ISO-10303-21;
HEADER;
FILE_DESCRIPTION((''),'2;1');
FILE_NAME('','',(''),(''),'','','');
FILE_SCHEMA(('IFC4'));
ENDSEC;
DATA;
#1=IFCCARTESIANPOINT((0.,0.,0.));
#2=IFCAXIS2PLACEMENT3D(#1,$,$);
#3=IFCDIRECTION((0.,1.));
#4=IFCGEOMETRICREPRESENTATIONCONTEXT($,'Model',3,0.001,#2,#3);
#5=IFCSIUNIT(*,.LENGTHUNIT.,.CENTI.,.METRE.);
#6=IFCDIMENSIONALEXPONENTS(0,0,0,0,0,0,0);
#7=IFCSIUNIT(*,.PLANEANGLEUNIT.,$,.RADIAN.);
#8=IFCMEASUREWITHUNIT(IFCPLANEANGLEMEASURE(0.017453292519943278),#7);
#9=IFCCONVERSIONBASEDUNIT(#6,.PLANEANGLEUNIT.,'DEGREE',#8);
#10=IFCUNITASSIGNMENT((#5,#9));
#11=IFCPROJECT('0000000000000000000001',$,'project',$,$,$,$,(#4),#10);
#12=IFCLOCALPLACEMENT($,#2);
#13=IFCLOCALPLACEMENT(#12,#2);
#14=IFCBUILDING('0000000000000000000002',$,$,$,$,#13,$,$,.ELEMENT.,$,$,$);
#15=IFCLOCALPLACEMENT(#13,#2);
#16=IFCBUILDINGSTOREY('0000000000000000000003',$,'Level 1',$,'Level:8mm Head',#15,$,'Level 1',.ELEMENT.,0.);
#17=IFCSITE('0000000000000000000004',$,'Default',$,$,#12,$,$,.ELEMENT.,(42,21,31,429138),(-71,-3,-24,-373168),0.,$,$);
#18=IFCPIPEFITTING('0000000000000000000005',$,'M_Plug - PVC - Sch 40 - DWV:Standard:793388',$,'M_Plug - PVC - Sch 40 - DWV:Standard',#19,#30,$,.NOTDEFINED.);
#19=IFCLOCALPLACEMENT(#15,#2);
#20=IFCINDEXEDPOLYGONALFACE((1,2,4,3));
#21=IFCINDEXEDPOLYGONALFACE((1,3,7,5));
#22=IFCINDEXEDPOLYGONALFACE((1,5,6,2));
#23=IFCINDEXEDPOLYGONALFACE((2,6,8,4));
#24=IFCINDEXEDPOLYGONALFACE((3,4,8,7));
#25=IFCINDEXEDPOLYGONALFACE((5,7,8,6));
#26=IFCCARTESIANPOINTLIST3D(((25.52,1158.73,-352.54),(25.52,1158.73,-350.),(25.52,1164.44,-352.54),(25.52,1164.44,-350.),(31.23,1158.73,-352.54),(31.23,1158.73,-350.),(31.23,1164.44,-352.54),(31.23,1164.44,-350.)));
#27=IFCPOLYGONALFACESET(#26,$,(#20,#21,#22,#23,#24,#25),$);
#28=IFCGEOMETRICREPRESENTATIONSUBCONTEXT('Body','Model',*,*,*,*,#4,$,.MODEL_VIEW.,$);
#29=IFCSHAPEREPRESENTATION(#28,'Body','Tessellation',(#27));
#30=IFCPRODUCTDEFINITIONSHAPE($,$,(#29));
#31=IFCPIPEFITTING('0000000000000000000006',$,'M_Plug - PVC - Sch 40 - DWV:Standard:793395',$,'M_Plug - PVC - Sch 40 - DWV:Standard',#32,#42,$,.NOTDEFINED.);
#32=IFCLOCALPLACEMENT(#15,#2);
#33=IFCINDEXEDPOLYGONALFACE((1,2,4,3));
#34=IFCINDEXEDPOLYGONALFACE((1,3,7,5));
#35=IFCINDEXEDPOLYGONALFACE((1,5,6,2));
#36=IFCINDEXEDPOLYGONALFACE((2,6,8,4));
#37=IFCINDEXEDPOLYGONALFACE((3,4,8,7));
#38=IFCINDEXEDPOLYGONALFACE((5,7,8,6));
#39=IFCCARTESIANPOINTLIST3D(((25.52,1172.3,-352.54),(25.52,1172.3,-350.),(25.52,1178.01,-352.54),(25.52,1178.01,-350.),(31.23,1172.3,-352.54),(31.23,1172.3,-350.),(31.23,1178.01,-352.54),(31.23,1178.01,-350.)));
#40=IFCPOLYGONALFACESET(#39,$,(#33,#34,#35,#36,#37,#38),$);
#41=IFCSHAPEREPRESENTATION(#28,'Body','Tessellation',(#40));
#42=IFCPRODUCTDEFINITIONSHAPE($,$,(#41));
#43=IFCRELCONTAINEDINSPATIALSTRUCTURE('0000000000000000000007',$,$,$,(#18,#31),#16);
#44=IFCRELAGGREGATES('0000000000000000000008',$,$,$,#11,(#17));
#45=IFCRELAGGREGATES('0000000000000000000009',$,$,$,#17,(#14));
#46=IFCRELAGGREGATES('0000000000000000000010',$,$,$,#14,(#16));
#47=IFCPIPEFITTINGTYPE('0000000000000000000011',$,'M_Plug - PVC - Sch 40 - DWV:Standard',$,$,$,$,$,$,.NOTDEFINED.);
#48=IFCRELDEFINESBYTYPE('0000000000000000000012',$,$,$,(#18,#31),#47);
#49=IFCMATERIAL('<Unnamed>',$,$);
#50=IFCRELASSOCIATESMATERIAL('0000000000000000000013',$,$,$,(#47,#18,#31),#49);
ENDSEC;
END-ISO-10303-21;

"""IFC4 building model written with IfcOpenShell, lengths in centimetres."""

from ifc_helpers import new_model, entity, si_unit, converted_unit, direction, frame, origin, place, context, subcontext, project, spatial, indexed_curve, outline, extrude, source, transform, mapped, material, type_object, type_shapes, element, save


model = new_model("IFC4")

# Units and contexts
model_context = context("Model", 3, precision=0.001, world=origin(), true_north=direction((0.0, 1.0)))
body_context = subcontext(model_context, "Body", "Model", "MODEL_VIEW")
ifc_project = project(units=[si_unit("LENGTHUNIT", "METRE", prefix="CENTI"), converted_unit("PLANEANGLEUNIT", "DEGREE", entity("IfcPlaneAngleMeasure", 0.017453292519943278), si_unit("PLANEANGLEUNIT", "RADIAN"), dimensions=[0, 0, 0, 0, 0, 0, 0])], contexts=[model_context])

# Site, building, storey
site_placement = place(None, origin())
site = spatial("IfcSite", under=ifc_project, at=site_placement, Name="Default", CompositionType="ELEMENT", RefLatitude=(42, 21, 31, 429138), RefLongitude=(-71, -3, -24, -373168), RefElevation=0.0)
building_placement = place(site_placement, origin())
building = spatial("IfcBuilding", under=site, at=building_placement, CompositionType="ELEMENT")
storey_placement = place(building_placement, origin())
storey = spatial("IfcBuildingStorey", under=building, at=storey_placement, Name="Level 1", ObjectType="Level:8mm Head", LongName="Level 1", CompositionType="ELEMENT", Elevation=0.0)

# Pipe fittings
ifc_material = material(Name="<Unnamed>")
pipe_fitting_type_1 = type_object("IfcPipeFittingType", Name="M_Plug - PVC - Sch 40 - DWV:Standard", PredefinedType="NOTDEFINED", material=ifc_material)
shared_shape_1 = source(origin(), body_context, "Body", "SweptSolid", [
    extrude(outline(indexed_curve([(-1.27, -2.86), (1.27, -2.86), (1.27, 2.86), (-1.27, 2.86), (-1.27, -2.86)], self_intersect=False)), frame((1.27, 0.0, -2.86), z_axis=(0.0, 0.0, 1.0), x_axis=(-1.0, 0.0, 0.0)), (0.0, 0.0, 1.0), 5.71),
])
type_shapes(pipe_fitting_type_1, [shared_shape_1])
for number, where, z_axis, x_axis, name in (
    (1, (28.38, 1161.59, -350.0), (1.0, 0.0, 0.0), (0.0, 0.0, -1.0), "M_Plug - PVC - Sch 40 - DWV:Standard:793388"),
    (2, (28.38, 1175.15, -350.0), (1.0, 0.0, 0.0), (0.0, 0.0, -1.0), "M_Plug - PVC - Sch 40 - DWV:Standard:793395"),
):
    element("IfcPipeFitting", number, at=place(storey_placement, frame(where, z_axis=z_axis, x_axis=x_axis)), inside=storey, type_object=pipe_fitting_type_1, material=ifc_material, Name=name, ObjectType="M_Plug - PVC - Sch 40 - DWV:Standard", PredefinedType="NOTDEFINED", context=body_context, shape_type="MappedRepresentation", body=[
        mapped(shared_shape_1, transform((0.0, 0.0, 0.0), scale=1.0)),
    ])

save(model, "model.ifc")
